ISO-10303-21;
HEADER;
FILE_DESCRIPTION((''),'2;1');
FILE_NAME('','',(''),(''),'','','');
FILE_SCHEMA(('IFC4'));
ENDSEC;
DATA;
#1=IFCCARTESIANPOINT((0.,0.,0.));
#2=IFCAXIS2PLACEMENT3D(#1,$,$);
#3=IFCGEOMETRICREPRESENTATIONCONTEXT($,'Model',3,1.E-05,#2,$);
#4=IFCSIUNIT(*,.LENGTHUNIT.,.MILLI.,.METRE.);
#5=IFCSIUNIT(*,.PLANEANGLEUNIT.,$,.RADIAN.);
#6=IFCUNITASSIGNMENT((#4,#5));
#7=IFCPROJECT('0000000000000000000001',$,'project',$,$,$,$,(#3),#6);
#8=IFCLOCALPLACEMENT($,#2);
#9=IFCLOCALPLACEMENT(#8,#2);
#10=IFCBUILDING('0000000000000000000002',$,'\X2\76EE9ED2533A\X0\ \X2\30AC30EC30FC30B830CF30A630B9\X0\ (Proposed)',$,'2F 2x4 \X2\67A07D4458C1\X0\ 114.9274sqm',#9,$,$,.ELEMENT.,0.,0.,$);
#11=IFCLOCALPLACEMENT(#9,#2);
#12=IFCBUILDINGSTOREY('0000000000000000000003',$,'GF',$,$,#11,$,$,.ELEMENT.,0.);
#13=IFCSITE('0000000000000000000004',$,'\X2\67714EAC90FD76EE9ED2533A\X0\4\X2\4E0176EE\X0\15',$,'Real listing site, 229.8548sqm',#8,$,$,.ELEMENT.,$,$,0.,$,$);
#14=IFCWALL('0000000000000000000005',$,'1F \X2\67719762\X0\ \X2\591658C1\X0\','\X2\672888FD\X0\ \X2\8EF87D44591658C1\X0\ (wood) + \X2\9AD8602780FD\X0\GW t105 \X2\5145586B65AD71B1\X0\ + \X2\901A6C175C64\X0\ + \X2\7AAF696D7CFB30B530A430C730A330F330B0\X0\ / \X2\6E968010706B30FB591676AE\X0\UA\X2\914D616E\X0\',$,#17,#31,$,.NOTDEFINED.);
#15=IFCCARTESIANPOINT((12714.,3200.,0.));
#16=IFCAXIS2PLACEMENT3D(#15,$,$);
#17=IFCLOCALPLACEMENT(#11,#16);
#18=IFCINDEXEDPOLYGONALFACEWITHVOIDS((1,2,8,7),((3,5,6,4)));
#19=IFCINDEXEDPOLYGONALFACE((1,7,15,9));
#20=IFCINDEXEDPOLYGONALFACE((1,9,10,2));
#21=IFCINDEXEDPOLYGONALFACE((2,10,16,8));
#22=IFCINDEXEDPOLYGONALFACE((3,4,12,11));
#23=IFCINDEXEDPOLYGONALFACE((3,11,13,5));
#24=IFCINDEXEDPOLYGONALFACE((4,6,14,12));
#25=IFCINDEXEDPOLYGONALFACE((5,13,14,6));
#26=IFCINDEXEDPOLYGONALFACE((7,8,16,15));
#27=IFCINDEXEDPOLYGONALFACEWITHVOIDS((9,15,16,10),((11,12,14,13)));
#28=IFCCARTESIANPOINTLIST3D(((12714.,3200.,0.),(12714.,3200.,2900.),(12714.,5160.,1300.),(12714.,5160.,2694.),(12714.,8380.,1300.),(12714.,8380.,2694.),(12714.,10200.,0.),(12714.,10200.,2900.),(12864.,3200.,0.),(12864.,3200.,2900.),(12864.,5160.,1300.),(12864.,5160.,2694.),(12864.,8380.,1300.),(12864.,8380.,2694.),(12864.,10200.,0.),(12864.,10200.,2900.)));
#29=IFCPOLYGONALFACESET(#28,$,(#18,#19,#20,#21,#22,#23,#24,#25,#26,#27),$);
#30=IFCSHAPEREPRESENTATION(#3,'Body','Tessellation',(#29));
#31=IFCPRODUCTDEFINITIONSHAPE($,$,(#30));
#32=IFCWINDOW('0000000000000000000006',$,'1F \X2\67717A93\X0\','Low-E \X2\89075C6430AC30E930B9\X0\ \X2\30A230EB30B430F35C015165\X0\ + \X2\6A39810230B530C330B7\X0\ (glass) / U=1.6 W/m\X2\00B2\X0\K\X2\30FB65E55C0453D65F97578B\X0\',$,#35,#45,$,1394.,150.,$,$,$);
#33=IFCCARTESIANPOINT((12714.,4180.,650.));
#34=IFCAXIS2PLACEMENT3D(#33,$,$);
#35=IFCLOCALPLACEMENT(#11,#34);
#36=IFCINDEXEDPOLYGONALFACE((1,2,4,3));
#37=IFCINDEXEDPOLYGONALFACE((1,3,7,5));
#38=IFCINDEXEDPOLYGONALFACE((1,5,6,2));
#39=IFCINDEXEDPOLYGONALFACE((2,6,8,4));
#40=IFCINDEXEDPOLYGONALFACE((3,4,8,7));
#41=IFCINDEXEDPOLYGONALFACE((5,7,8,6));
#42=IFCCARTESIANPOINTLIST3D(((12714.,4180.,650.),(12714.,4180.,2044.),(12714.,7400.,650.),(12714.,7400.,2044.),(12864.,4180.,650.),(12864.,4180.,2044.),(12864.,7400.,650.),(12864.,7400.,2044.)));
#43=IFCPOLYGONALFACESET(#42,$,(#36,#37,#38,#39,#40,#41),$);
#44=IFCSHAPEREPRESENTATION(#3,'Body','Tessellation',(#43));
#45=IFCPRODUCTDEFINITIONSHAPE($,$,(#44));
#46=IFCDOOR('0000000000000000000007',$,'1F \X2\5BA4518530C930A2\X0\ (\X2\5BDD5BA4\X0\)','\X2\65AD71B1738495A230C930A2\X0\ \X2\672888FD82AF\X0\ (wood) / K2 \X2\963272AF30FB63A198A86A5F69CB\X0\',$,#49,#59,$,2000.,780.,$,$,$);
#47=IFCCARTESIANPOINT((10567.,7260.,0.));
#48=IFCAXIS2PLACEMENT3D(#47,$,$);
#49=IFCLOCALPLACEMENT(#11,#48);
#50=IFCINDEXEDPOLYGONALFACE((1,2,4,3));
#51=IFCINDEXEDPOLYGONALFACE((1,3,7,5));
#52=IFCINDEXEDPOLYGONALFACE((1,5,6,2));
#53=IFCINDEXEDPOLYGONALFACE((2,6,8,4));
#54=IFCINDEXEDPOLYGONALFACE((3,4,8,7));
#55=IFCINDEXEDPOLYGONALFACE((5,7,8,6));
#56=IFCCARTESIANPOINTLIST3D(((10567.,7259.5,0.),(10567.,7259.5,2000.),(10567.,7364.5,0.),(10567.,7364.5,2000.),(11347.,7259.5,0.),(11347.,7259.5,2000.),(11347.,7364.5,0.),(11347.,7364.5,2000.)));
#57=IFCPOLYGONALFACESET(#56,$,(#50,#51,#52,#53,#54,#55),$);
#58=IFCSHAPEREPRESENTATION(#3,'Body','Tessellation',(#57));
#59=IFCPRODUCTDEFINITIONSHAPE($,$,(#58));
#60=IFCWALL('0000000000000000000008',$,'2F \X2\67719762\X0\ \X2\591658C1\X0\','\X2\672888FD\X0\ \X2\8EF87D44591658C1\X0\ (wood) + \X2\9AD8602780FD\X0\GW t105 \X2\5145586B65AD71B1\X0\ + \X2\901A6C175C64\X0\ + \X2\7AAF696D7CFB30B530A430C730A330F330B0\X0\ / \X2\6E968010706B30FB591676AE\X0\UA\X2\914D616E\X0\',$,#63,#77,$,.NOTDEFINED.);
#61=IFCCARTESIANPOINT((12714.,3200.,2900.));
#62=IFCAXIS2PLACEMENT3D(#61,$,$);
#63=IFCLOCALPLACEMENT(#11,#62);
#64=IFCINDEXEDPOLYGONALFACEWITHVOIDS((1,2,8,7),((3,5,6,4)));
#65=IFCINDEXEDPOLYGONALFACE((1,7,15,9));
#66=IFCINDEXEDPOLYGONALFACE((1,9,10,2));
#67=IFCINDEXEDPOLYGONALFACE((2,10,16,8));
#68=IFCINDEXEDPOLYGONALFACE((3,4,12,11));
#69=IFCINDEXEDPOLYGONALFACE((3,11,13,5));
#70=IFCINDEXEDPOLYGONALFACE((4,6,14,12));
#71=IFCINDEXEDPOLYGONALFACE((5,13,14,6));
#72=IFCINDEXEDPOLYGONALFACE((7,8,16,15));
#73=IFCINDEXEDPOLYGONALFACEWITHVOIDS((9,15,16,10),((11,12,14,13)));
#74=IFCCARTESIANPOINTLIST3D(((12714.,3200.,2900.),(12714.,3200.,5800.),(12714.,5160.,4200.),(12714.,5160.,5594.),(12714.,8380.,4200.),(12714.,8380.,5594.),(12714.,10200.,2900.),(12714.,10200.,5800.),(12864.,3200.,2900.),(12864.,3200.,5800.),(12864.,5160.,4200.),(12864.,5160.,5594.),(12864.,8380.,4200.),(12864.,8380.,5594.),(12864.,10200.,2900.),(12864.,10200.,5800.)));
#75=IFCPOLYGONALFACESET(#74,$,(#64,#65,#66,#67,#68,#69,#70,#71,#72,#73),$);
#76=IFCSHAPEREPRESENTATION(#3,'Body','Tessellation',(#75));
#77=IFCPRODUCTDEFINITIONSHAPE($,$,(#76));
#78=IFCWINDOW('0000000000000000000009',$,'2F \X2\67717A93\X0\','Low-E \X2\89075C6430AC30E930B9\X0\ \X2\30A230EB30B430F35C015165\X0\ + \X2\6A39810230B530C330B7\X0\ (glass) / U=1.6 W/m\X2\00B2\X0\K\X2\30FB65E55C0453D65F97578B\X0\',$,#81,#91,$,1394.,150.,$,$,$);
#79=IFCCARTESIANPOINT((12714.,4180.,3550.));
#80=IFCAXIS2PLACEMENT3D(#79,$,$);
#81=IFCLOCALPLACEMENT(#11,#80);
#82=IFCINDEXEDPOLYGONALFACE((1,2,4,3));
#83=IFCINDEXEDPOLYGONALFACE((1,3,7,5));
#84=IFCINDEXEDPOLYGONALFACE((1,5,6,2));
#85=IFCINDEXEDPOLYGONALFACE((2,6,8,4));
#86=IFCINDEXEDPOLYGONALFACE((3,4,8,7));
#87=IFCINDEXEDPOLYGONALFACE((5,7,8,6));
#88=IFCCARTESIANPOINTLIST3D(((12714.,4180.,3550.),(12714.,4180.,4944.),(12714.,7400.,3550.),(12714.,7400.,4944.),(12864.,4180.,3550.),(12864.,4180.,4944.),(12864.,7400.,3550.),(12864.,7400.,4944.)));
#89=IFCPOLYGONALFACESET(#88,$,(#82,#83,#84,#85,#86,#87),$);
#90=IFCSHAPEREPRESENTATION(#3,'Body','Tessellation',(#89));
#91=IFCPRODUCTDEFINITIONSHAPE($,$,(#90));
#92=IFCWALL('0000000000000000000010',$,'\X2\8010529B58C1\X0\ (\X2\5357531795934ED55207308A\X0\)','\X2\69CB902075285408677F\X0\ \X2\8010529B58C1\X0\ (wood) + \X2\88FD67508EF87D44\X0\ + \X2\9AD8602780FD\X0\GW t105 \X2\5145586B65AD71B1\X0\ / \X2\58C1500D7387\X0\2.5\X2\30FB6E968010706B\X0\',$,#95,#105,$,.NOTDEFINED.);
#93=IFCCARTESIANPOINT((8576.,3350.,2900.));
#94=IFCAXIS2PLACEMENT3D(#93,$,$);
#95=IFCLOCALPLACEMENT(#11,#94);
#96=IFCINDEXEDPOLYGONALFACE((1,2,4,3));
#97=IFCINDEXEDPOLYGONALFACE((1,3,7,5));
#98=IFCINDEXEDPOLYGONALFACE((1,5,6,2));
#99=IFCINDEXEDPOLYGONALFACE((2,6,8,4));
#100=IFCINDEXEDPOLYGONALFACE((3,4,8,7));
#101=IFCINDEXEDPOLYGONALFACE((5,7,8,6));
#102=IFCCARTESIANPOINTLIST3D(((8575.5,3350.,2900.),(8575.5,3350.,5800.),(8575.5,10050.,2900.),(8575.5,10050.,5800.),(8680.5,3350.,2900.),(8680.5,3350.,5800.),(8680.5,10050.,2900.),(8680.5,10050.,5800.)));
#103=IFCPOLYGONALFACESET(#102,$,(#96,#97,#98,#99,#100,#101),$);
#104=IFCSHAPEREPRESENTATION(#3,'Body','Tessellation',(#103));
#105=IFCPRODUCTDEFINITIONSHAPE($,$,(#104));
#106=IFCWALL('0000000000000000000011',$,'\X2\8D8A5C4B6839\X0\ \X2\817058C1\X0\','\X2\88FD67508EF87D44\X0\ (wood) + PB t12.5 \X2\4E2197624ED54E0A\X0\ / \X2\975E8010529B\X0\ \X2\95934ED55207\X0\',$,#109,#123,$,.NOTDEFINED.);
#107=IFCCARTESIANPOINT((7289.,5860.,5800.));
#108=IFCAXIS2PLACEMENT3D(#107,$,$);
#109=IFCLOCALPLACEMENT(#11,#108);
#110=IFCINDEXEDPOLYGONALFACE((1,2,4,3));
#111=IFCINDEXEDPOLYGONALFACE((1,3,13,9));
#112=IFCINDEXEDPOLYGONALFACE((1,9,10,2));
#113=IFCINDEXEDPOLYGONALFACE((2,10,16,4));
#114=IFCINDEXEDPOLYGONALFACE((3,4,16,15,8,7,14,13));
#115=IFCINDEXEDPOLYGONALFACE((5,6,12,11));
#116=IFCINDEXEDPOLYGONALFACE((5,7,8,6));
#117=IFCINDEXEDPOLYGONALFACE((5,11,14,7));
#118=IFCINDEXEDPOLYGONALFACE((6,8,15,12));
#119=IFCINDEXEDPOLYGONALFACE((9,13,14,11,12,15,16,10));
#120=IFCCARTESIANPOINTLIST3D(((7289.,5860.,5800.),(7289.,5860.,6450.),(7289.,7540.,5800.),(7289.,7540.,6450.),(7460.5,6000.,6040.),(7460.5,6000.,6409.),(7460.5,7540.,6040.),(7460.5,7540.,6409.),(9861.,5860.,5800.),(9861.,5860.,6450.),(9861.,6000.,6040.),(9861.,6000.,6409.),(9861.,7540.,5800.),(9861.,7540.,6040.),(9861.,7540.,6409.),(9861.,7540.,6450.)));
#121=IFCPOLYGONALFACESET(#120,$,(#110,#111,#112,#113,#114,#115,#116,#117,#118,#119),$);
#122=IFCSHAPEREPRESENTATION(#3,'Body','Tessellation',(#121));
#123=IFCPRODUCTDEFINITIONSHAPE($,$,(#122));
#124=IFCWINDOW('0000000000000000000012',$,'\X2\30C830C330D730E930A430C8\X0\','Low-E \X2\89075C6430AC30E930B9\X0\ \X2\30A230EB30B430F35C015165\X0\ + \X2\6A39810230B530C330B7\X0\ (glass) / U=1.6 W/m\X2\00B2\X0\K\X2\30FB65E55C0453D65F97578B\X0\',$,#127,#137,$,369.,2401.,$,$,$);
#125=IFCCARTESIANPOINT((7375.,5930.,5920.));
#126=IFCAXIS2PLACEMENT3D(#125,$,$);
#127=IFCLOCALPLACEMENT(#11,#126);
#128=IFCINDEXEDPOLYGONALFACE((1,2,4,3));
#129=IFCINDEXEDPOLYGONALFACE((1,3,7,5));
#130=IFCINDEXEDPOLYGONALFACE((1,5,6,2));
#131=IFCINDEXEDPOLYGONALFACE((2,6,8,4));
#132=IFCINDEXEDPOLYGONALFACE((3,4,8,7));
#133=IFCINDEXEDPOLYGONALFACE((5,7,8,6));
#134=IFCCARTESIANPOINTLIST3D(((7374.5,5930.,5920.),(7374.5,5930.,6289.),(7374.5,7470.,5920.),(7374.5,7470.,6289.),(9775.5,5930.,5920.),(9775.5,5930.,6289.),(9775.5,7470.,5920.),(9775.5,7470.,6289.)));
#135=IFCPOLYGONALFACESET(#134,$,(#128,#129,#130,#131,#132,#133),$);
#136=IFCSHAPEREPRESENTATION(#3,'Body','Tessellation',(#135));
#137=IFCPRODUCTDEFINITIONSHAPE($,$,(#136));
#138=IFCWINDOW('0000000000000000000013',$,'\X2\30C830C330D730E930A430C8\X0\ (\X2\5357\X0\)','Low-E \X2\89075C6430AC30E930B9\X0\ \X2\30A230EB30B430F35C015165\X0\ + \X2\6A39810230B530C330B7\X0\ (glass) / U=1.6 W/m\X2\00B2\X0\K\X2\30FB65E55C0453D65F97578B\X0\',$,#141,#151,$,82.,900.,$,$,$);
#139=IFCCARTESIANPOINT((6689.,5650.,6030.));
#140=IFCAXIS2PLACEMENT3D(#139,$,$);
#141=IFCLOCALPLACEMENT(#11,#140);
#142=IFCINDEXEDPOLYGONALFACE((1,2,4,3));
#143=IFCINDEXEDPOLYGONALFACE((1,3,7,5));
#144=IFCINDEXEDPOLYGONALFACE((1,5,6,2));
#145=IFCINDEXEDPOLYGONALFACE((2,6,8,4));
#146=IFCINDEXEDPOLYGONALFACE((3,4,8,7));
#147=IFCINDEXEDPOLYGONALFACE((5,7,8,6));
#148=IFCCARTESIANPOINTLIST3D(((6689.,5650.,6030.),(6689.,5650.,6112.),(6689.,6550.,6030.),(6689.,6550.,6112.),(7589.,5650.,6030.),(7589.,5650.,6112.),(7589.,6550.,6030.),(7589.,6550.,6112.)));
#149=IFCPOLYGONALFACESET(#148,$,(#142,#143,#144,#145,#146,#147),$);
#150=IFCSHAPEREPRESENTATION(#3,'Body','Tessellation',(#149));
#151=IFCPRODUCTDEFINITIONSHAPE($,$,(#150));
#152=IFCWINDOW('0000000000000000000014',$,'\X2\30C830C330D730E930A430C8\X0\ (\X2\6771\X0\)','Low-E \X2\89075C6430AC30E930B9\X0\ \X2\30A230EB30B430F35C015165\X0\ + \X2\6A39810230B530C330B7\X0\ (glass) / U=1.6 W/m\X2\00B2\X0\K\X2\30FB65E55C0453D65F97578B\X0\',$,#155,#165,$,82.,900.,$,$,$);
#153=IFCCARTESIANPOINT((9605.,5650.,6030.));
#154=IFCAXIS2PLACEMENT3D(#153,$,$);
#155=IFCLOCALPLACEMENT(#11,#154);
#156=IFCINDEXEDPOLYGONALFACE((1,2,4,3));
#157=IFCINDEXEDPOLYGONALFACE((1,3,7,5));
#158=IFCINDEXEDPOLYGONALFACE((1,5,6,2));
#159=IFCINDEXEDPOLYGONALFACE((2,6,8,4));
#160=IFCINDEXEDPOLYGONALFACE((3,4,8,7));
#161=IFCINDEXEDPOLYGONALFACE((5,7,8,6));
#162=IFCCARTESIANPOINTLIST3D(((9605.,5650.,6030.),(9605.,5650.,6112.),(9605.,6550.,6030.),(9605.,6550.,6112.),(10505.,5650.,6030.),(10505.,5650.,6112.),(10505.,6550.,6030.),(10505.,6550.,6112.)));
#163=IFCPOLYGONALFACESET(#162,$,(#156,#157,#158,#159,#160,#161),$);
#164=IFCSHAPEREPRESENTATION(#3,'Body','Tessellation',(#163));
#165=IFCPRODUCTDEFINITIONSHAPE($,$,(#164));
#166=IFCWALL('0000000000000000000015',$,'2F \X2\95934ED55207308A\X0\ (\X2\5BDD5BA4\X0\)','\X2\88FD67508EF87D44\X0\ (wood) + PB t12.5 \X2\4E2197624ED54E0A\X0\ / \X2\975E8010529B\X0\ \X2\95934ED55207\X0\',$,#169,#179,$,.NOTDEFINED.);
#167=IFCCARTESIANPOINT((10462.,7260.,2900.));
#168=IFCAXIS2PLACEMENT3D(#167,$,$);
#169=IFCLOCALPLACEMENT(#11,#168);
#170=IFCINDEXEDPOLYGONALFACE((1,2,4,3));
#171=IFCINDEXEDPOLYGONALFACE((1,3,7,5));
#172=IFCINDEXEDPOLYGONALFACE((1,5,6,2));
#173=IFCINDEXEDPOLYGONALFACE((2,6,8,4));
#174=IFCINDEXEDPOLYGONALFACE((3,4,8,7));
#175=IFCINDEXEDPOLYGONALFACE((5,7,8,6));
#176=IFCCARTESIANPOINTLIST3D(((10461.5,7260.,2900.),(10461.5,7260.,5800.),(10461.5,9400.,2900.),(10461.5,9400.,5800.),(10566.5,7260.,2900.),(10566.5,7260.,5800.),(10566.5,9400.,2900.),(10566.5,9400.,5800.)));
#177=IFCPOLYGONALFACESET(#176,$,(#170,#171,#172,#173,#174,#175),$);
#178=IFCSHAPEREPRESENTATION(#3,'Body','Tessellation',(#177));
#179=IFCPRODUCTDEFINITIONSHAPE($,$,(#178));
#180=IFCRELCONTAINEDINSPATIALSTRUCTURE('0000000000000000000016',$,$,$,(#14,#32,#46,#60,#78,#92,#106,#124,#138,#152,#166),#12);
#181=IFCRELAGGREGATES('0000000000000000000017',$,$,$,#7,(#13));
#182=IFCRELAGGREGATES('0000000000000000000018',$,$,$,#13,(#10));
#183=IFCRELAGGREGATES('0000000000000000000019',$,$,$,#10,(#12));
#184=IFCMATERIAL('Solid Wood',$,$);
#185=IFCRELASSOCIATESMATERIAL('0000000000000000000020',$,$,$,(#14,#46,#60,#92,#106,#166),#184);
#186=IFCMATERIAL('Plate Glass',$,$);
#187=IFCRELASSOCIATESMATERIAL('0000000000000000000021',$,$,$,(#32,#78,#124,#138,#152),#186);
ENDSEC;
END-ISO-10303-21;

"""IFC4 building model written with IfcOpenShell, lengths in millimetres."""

from ifc_helpers import new_model, si_unit, frame, frame_2d, origin, place, context, project, spatial, rectangle, extrude, material, element, fill, save


model = new_model("IFC4")

# Units and contexts
model_context = context("Model", 3, precision=1e-05, world=origin())
ifc_project = project(units=[si_unit("LENGTHUNIT", "METRE", prefix="MILLI"), si_unit("PLANEANGLEUNIT", "RADIAN")], contexts=[model_context])

# Site, building, storey
site_placement = place(None, origin())
site = spatial("IfcSite", under=ifc_project, at=site_placement, Name="東京都目黒区4丁目15", ObjectType="Real listing site, 229.8548sqm", CompositionType="ELEMENT", RefElevation=0.0)
building_placement = place(site_placement, origin())
building = spatial("IfcBuilding", under=site, at=building_placement, Name="目黒区 ガレージハウス (Proposed)", ObjectType="2F 2x4 枠組壁 114.9274sqm", CompositionType="ELEMENT", ElevationOfRefHeight=0.0, ElevationOfTerrain=0.0)
storey_placement = place(building_placement, origin())
storey = spatial("IfcBuildingStorey", under=building, at=storey_placement, Name="GF", CompositionType="ELEMENT", Elevation=0.0)

# Wall, opening, window
ifc_material_1 = material(Name="Solid Wood")
wall_1_placement = place(storey_placement, frame((12714.0, 3200.0, 0.0)))
wall_1 = element("IfcWall", 1, at=wall_1_placement, inside=storey, material=ifc_material_1, Name="1F 東面 外壁", Description="木製 軸組外壁 (wood) + 高性能GW t105 充填断熱 + 通気層 + 窯業系サイディング / 準耐火・外皮UA配慮", PredefinedType="NOTDEFINED", context=model_context, shape_type="SweptSolid", body=[
    extrude(rectangle(XDim=150.0, YDim=7000.0, at=frame_2d((75.0, 3500.0))), frame((12714.0, 3200.0, 0.0)), (0.0, 0.0, 1.0), 2900.0),
])
opening_1_placement = place(storey_placement, frame((12714.0, 4180.0, 650.0)))
opening_1 = element("IfcOpeningElement", 2, at=opening_1_placement, cuts=wall_1, PredefinedType="NOTDEFINED", context=model_context, shape_type="SweptSolid", body=[
    extrude(rectangle(XDim=150.0, YDim=3220.0, at=frame_2d((75.0, 1610.0))), frame((12714.0, 4180.0, 650.0)), (0.0, 0.0, 1.0), 1394.0),
])
ifc_material_2 = material(Name="Plate Glass")
window_1_placement = place(storey_placement, frame((12714.0, 4180.0, 650.0)))
window_1 = element("IfcWindow", 3, at=window_1_placement, inside=storey, material=ifc_material_2, Name="1F 東窓", Description="Low-E 複層ガラス アルゴン封入 + 樹脂サッシ (glass) / U=1.6 W/m²K・日射取得型", OverallHeight=1394.0, OverallWidth=150.0, context=model_context, shape_type="SweptSolid", body=[
    extrude(rectangle(XDim=150.0, YDim=3220.0, at=frame_2d((75.0, 1610.0))), frame((12714.0, 4180.0, 650.0)), (0.0, 0.0, 1.0), 1394.0),
])
fill(opening_1, window_1)

# Door
door_1_placement = place(storey_placement, frame((10567.0, 7260.0, 0.0)))
element("IfcDoor", 4, at=door_1_placement, inside=storey, material=ifc_material_1, Name="1F 室内ドア (寝室)", Description="断熱玄関ドア 木製芯 (wood) / K2 防犯・採風機構", OverallHeight=2000.0, OverallWidth=780.0, context=model_context, shape_type="SweptSolid", body=[
    extrude(rectangle(XDim=780.0, YDim=105.0, at=frame_2d((390.0, 52.0))), frame((10567.0, 7260.0, 0.0)), (0.0, 0.0, 1.0), 2000.0),
])

# Wall, opening, window
wall_2_placement = place(storey_placement, frame((12714.0, 3200.0, 2900.0)))
wall_2 = element("IfcWall", 5, at=wall_2_placement, inside=storey, material=ifc_material_1, Name="2F 東面 外壁", Description="木製 軸組外壁 (wood) + 高性能GW t105 充填断熱 + 通気層 + 窯業系サイディング / 準耐火・外皮UA配慮", PredefinedType="NOTDEFINED", context=model_context, shape_type="SweptSolid", body=[
    extrude(rectangle(XDim=150.0, YDim=7000.0, at=frame_2d((75.0, 3500.0))), frame((12714.0, 3200.0, 2900.0)), (0.0, 0.0, 1.0), 2900.0),
])
opening_2_placement = place(storey_placement, frame((12714.0, 4180.0, 3550.0)))
opening_2 = element("IfcOpeningElement", 6, at=opening_2_placement, cuts=wall_2, PredefinedType="NOTDEFINED", context=model_context, shape_type="SweptSolid", body=[
    extrude(rectangle(XDim=150.0, YDim=3220.0, at=frame_2d((75.0, 1610.0))), frame((12714.0, 4180.0, 3550.0)), (0.0, 0.0, 1.0), 1394.0),
])
window_2_placement = place(storey_placement, frame((12714.0, 4180.0, 3550.0)))
window_2 = element("IfcWindow", 7, at=window_2_placement, inside=storey, material=ifc_material_2, Name="2F 東窓", Description="Low-E 複層ガラス アルゴン封入 + 樹脂サッシ (glass) / U=1.6 W/m²K・日射取得型", OverallHeight=1394.0, OverallWidth=150.0, context=model_context, shape_type="SweptSolid", body=[
    extrude(rectangle(XDim=150.0, YDim=3220.0, at=frame_2d((75.0, 1610.0))), frame((12714.0, 4180.0, 3550.0)), (0.0, 0.0, 1.0), 1394.0),
])
fill(opening_2, window_2)

# Wall
wall_3_placement = place(storey_placement, frame((8576.0, 3350.0, 2900.0)))
element("IfcWall", 8, at=wall_3_placement, inside=storey, material=ifc_material_1, Name="耐力壁 (南北間仕切り)", Description="構造用合板 耐力壁 (wood) + 製材軸組 + 高性能GW t105 充填断熱 / 壁倍率2.5・準耐火", PredefinedType="NOTDEFINED", context=model_context, shape_type="SweptSolid", body=[
    extrude(rectangle(XDim=105.0, YDim=6700.0, at=frame_2d((52.0, 3350.0))), frame((8576.0, 3350.0, 2900.0)), (0.0, 0.0, 1.0), 2900.0),
])

# Wall, openings, windows
wall_4_placement = place(storey_placement, frame((7289.0, 5860.0, 5800.0)))
wall_4 = element("IfcWall", 9, at=wall_4_placement, inside=storey, material=ifc_material_1, Name="越屋根 腰壁", Description="製材軸組 (wood) + PB t12.5 両面仕上 / 非耐力 間仕切", PredefinedType="NOTDEFINED", context=model_context, shape_type="SweptSolid", body=[
    extrude(rectangle(XDim=2572.0, YDim=1680.0, at=frame_2d((1286.0, 840.0))), frame((7289.0, 5860.0, 5800.0)), (0.0, 0.0, 1.0), 650.0),
])
opening_3_placement = place(storey_placement, frame((7375.0, 5930.0, 5920.0)))
opening_3 = element("IfcOpeningElement", 10, at=opening_3_placement, cuts=wall_4, PredefinedType="NOTDEFINED", context=model_context, shape_type="SweptSolid", body=[
    extrude(rectangle(XDim=2401.0, YDim=1540.0, at=frame_2d((1200.0, 770.0))), frame((7375.0, 5930.0, 5920.0)), (0.0, 0.0, 1.0), 369.0),
])
opening_4_placement = place(storey_placement, frame((6689.0, 5650.0, 6030.0)))
opening_4 = element("IfcOpeningElement", 11, at=opening_4_placement, cuts=wall_4, PredefinedType="NOTDEFINED", context=model_context, shape_type="SweptSolid", body=[
    extrude(rectangle(XDim=900.0, YDim=900.0, at=frame_2d((450.0, 450.0))), frame((6689.0, 5650.0, 6030.0)), (0.0, 0.0, 1.0), 82.0),
])
opening_5_placement = place(storey_placement, frame((9605.0, 5650.0, 6030.0)))
opening_5 = element("IfcOpeningElement", 12, at=opening_5_placement, cuts=wall_4, PredefinedType="NOTDEFINED", context=model_context, shape_type="SweptSolid", body=[
    extrude(rectangle(XDim=900.0, YDim=900.0, at=frame_2d((450.0, 450.0))), frame((9605.0, 5650.0, 6030.0)), (0.0, 0.0, 1.0), 82.0),
])
window_3_placement = place(storey_placement, frame((7375.0, 5930.0, 5920.0)))
window_3 = element("IfcWindow", 13, at=window_3_placement, inside=storey, material=ifc_material_2, Name="トップライト", Description="Low-E 複層ガラス アルゴン封入 + 樹脂サッシ (glass) / U=1.6 W/m²K・日射取得型", OverallHeight=369.0, OverallWidth=2401.0, context=model_context, shape_type="SweptSolid", body=[
    extrude(rectangle(XDim=2401.0, YDim=1540.0, at=frame_2d((1200.0, 770.0))), frame((7375.0, 5930.0, 5920.0)), (0.0, 0.0, 1.0), 369.0),
])
fill(opening_3, window_3)
window_4_placement = place(storey_placement, frame((6689.0, 5650.0, 6030.0)))
window_4 = element("IfcWindow", 14, at=window_4_placement, inside=storey, material=ifc_material_2, Name="トップライト (南)", Description="Low-E 複層ガラス アルゴン封入 + 樹脂サッシ (glass) / U=1.6 W/m²K・日射取得型", OverallHeight=82.0, OverallWidth=900.0, context=model_context, shape_type="SweptSolid", body=[
    extrude(rectangle(XDim=900.0, YDim=900.0, at=frame_2d((450.0, 450.0))), frame((6689.0, 5650.0, 6030.0)), (0.0, 0.0, 1.0), 82.0),
])
fill(opening_4, window_4)
window_5_placement = place(storey_placement, frame((9605.0, 5650.0, 6030.0)))
window_5 = element("IfcWindow", 15, at=window_5_placement, inside=storey, material=ifc_material_2, Name="トップライト (東)", Description="Low-E 複層ガラス アルゴン封入 + 樹脂サッシ (glass) / U=1.6 W/m²K・日射取得型", OverallHeight=82.0, OverallWidth=900.0, context=model_context, shape_type="SweptSolid", body=[
    extrude(rectangle(XDim=900.0, YDim=900.0, at=frame_2d((450.0, 450.0))), frame((9605.0, 5650.0, 6030.0)), (0.0, 0.0, 1.0), 82.0),
])
fill(opening_5, window_5)

# Wall
wall_5_placement = place(storey_placement, frame((10462.0, 7260.0, 2900.0)))
element("IfcWall", 16, at=wall_5_placement, inside=storey, material=ifc_material_1, Name="2F 間仕切り (寝室)", Description="製材軸組 (wood) + PB t12.5 両面仕上 / 非耐力 間仕切", PredefinedType="NOTDEFINED", context=model_context, shape_type="SweptSolid", body=[
    extrude(rectangle(XDim=105.0, YDim=2140.0, at=frame_2d((52.0, 1070.0))), frame((10462.0, 7260.0, 2900.0)), (0.0, 0.0, 1.0), 2900.0),
])

save(model, "model.ifc")
